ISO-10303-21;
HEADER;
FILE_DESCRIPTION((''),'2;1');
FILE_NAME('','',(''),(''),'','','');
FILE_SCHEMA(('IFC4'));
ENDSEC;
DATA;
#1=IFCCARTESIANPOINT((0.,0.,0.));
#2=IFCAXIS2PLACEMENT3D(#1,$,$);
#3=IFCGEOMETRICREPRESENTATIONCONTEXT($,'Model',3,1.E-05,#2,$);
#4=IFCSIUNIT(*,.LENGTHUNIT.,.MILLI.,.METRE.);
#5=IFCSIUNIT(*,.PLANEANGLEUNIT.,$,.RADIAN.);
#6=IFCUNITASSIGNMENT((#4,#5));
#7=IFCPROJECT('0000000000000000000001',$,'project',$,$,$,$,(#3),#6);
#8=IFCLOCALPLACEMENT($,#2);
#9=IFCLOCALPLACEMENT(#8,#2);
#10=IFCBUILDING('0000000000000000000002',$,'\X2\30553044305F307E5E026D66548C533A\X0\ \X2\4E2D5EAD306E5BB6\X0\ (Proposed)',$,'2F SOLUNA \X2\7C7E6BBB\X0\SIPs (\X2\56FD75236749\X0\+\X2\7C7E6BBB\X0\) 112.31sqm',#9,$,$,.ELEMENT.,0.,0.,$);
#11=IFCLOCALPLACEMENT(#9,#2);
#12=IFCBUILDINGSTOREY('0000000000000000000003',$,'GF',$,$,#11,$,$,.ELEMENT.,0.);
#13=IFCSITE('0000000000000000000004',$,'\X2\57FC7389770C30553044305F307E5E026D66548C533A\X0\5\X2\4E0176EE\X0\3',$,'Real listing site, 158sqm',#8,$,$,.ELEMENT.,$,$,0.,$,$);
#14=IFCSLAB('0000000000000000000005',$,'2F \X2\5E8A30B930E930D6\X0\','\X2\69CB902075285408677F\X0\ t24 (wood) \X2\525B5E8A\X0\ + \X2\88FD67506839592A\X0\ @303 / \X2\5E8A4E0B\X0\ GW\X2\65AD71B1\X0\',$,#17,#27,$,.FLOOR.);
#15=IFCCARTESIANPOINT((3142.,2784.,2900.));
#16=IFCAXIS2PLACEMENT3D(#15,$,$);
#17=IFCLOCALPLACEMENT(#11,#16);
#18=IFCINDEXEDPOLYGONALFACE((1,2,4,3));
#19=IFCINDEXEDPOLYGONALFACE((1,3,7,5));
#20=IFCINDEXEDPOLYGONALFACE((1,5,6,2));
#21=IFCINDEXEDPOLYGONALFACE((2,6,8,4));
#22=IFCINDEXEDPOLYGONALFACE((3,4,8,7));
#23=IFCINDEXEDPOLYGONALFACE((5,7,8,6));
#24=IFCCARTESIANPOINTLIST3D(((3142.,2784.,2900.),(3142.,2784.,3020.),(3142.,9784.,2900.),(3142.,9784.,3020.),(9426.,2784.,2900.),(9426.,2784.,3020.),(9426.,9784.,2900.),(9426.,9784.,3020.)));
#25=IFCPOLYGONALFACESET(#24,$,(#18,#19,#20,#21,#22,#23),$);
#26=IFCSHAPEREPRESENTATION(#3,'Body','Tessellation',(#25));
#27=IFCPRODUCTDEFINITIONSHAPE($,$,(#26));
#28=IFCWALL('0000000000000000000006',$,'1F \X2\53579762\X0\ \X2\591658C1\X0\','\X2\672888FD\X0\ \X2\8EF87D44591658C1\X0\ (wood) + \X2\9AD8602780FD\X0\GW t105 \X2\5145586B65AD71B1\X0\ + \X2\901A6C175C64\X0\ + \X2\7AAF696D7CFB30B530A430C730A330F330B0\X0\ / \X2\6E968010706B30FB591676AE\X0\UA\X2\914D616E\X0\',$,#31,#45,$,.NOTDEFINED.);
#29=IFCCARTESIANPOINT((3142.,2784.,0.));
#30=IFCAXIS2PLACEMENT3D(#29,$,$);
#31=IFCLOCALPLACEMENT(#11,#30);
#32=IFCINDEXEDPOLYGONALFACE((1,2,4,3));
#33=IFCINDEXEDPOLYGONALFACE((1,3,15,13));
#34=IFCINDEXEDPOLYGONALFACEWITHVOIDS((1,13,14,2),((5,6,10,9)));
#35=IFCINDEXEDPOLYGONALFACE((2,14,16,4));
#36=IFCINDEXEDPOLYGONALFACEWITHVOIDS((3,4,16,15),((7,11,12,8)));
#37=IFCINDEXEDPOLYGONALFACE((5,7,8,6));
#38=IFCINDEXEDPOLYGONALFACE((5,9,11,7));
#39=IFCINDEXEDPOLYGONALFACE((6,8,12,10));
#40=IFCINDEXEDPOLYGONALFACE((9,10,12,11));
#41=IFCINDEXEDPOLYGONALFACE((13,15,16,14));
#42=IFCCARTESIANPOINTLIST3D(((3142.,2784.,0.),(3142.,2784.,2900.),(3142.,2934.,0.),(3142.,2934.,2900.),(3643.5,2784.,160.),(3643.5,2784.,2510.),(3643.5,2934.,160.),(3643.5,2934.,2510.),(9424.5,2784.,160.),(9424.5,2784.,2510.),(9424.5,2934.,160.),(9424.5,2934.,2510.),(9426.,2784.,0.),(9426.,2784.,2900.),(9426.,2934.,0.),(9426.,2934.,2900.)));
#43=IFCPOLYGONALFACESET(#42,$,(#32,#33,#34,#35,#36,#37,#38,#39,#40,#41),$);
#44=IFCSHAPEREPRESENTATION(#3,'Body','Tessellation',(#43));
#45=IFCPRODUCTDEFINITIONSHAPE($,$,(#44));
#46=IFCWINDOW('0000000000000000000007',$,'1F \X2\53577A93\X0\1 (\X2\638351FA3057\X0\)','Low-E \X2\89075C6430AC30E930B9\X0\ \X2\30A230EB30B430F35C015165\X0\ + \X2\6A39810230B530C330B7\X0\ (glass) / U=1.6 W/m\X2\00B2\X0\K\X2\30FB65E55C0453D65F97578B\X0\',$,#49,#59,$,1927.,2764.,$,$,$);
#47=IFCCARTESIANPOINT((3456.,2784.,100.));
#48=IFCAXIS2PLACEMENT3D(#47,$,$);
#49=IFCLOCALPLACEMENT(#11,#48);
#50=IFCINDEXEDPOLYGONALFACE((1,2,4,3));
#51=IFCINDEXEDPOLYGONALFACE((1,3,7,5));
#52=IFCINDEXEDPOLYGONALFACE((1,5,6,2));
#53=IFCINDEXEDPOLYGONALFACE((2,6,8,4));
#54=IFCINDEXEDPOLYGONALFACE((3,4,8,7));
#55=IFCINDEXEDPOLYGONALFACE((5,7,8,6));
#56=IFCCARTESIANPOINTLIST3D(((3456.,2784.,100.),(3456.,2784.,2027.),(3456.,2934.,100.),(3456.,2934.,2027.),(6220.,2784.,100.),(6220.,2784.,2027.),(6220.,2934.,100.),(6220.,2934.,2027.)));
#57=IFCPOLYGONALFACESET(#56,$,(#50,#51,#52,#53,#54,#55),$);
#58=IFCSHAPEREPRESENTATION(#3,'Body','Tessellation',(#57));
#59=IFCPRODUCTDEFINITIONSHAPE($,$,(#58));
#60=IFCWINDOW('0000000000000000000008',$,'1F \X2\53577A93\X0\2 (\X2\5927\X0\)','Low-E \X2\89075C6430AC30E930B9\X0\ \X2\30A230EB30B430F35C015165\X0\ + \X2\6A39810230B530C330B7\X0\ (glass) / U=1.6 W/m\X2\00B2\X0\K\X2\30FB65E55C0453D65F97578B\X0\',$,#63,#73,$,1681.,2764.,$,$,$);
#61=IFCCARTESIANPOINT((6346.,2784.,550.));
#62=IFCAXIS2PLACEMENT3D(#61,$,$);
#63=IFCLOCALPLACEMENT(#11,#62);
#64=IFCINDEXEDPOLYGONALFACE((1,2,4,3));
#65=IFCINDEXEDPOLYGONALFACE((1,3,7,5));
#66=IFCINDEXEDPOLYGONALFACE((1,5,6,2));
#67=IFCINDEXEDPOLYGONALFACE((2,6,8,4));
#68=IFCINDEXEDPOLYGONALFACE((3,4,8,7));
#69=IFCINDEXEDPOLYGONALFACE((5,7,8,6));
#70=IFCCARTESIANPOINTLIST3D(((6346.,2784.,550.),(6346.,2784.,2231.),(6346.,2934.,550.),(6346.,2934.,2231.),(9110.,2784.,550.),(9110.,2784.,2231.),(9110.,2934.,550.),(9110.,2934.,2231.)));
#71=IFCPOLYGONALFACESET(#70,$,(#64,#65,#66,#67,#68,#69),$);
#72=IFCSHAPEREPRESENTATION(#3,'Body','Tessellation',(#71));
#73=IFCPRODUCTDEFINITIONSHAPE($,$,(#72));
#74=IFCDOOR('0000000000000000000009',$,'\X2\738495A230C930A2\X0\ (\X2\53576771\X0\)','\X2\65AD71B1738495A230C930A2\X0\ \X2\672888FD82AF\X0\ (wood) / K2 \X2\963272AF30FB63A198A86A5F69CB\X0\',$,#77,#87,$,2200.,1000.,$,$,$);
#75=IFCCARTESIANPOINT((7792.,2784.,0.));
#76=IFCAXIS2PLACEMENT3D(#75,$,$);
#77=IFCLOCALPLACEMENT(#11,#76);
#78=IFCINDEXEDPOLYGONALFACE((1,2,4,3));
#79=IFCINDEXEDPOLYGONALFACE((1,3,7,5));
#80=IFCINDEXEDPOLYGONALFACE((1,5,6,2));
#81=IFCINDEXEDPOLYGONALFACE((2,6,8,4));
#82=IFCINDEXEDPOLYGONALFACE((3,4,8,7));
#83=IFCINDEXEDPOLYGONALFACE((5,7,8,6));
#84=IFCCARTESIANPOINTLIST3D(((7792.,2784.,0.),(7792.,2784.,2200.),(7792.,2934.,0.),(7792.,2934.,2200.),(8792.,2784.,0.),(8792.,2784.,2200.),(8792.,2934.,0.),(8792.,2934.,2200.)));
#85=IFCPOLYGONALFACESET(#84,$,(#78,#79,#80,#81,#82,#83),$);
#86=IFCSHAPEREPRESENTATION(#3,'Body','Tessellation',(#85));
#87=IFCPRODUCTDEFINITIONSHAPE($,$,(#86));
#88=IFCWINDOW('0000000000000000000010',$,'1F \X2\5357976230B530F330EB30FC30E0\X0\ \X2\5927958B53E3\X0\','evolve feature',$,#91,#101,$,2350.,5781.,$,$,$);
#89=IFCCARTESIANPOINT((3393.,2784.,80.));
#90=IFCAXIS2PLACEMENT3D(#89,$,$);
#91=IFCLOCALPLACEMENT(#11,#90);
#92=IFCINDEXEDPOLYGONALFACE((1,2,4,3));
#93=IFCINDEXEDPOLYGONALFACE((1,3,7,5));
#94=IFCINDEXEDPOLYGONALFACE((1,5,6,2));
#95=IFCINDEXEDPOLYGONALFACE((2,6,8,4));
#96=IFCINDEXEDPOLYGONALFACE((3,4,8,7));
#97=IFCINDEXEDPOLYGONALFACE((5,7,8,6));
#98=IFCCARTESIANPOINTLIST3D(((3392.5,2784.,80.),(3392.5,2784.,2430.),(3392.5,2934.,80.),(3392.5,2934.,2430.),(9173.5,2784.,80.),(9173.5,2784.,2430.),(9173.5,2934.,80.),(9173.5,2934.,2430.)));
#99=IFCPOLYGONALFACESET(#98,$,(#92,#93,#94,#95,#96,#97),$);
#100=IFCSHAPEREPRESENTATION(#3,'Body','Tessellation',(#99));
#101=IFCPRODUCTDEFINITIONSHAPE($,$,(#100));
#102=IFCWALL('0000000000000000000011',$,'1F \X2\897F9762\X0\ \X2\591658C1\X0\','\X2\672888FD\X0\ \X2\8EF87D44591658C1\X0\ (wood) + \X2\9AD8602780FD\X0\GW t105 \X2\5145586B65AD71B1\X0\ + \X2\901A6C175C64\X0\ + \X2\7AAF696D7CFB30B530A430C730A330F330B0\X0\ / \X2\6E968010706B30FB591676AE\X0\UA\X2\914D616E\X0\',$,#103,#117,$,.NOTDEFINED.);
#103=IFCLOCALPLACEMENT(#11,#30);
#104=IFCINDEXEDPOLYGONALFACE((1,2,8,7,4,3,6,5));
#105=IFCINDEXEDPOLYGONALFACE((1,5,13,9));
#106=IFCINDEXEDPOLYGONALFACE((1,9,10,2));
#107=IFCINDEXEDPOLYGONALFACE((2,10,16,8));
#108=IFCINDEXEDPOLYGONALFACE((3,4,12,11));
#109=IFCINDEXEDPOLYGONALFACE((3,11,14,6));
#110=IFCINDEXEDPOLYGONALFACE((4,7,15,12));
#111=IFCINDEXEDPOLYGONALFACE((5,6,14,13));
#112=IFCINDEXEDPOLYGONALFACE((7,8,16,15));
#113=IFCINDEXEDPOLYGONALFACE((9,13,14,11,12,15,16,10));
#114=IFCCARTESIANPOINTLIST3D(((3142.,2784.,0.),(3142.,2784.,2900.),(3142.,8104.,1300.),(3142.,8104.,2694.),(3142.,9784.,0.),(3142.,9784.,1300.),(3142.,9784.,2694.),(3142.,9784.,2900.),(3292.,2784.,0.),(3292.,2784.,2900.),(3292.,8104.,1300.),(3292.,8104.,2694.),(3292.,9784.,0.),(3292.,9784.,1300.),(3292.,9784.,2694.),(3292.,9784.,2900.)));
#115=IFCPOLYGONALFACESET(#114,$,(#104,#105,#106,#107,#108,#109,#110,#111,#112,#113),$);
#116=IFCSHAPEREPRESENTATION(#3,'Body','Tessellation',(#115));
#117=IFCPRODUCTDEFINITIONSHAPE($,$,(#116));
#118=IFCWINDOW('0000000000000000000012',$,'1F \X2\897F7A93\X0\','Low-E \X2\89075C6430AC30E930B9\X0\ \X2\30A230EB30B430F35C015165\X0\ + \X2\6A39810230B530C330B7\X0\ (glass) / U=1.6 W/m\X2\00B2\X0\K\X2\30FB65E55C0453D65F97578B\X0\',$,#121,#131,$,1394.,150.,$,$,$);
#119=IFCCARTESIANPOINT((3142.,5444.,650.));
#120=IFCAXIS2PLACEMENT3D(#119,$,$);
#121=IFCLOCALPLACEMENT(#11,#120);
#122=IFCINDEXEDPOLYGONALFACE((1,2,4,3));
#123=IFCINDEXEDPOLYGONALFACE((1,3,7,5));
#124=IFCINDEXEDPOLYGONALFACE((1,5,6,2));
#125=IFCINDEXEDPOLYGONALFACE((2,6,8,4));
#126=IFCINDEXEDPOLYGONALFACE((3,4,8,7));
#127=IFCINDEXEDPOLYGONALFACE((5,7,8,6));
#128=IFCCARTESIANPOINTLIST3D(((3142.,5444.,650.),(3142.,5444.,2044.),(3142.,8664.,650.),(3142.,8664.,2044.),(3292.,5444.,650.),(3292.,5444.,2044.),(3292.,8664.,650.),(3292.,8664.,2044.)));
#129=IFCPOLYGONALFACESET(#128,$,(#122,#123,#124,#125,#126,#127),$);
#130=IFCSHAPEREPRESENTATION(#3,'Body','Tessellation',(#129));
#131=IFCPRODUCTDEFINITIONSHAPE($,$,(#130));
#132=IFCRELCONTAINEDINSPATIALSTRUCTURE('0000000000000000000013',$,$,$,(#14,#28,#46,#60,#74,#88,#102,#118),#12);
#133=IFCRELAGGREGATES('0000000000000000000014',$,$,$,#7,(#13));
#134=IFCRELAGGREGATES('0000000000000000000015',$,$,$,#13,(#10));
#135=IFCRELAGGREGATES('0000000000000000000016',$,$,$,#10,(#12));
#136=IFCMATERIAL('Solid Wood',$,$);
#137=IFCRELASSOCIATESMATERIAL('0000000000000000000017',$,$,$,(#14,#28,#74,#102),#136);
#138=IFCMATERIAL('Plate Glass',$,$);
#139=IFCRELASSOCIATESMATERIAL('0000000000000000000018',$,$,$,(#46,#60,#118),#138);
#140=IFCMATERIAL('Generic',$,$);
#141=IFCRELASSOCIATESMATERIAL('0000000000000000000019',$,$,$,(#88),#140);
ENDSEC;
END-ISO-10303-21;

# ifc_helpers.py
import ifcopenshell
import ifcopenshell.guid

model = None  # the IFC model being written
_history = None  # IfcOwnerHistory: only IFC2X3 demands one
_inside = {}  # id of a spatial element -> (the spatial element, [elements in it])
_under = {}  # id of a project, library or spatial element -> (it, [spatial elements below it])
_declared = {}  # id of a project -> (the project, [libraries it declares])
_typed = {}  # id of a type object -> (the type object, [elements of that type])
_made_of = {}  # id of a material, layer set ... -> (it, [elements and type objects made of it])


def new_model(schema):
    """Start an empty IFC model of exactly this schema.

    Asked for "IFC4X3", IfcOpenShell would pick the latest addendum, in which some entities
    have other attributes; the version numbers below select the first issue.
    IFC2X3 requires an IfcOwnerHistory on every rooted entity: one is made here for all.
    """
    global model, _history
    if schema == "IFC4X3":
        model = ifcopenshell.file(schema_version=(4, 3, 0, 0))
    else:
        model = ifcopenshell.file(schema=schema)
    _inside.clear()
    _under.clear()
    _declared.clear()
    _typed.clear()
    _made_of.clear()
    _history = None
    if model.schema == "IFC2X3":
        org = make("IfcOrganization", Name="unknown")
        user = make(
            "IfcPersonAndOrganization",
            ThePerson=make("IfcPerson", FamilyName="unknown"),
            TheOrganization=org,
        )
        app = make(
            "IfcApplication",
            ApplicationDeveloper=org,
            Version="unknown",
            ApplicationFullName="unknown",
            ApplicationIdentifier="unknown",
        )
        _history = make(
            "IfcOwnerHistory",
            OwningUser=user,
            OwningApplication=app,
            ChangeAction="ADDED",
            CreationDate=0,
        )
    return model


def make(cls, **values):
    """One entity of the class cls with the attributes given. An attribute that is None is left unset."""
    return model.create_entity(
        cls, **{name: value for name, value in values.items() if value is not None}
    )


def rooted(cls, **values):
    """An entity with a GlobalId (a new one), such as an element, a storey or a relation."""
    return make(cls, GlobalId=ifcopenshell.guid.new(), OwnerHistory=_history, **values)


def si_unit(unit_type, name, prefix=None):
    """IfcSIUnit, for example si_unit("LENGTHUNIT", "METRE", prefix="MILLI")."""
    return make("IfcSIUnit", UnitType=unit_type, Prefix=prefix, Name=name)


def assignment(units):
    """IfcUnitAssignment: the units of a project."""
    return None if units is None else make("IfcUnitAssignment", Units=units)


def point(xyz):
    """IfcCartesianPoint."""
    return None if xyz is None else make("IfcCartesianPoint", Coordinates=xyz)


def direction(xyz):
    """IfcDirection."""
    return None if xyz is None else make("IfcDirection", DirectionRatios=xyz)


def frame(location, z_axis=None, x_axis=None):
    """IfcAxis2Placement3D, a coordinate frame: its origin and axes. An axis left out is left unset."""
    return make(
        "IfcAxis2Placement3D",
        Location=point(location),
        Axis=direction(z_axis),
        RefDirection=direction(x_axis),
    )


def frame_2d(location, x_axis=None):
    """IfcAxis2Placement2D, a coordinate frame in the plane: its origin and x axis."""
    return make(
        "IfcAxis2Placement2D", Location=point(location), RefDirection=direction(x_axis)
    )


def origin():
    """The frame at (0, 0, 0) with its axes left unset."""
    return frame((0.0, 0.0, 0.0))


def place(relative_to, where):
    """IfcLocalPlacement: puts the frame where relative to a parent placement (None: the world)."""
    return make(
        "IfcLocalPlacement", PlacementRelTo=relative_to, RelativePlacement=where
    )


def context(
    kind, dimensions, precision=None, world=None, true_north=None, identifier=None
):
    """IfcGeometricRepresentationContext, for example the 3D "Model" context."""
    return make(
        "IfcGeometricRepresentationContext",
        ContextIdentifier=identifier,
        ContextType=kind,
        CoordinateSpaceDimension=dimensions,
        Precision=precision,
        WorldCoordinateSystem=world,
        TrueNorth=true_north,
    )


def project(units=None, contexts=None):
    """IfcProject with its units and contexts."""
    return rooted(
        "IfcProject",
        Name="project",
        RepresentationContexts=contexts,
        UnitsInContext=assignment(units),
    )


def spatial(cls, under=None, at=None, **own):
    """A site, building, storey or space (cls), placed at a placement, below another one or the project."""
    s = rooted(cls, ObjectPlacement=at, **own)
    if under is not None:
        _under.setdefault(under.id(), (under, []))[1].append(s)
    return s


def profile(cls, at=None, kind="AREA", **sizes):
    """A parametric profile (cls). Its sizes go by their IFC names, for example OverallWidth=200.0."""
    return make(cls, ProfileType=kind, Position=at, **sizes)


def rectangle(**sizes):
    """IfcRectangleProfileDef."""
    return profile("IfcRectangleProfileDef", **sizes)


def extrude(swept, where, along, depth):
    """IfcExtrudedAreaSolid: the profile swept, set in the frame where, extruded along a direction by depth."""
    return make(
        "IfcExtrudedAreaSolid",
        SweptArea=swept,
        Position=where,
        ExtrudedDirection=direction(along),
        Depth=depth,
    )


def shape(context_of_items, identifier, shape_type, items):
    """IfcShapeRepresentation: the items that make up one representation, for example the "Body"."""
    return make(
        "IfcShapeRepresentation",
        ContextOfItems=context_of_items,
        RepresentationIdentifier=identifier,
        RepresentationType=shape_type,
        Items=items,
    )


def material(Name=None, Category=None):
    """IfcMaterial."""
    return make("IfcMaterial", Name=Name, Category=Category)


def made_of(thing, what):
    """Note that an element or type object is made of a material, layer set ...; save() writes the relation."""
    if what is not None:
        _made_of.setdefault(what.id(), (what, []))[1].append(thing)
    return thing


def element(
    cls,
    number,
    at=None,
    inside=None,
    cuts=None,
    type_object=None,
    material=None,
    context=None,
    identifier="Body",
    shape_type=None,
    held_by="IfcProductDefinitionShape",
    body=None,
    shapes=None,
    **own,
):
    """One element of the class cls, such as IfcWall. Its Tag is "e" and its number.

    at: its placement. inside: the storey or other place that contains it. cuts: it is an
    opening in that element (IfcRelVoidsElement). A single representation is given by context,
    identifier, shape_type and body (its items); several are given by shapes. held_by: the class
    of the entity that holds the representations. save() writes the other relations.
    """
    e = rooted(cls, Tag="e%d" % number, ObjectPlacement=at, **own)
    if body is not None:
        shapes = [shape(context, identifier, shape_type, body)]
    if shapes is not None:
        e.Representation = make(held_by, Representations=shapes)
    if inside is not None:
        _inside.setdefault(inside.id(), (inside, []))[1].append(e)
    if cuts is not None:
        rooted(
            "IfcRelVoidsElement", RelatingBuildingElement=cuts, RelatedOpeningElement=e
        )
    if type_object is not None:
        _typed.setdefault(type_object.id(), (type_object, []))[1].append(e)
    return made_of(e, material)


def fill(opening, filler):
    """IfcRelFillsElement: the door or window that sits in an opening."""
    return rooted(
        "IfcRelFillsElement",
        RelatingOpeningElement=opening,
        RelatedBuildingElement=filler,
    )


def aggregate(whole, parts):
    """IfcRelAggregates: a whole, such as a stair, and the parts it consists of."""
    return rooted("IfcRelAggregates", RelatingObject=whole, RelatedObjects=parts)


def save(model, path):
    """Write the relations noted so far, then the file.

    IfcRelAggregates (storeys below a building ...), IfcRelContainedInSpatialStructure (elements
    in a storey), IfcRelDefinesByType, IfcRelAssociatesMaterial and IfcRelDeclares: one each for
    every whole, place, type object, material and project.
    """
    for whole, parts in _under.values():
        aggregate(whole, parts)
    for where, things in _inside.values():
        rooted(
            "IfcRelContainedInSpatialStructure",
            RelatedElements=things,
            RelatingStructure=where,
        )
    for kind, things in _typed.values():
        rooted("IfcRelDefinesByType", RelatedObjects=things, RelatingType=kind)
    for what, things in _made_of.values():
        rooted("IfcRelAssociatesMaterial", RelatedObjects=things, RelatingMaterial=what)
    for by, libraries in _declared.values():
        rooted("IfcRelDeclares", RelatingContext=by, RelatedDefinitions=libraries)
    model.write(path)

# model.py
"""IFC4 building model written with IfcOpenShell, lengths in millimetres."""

from ifc_helpers import new_model, si_unit, frame, frame_2d, origin, place, context, project, spatial, rectangle, extrude, material, element, fill, save


model = new_model("IFC4")

# Units and contexts
model_context = context("Model", 3, precision=1e-05, world=origin())
ifc_project = project(units=[si_unit("LENGTHUNIT", "METRE", prefix="MILLI"), si_unit("PLANEANGLEUNIT", "RADIAN")], contexts=[model_context])

# Site, building, storey
site_placement = place(None, origin())
site = spatial("IfcSite", under=ifc_project, at=site_placement, Name="埼玉県さいたま市浦和区5丁目3", ObjectType="Real listing site, 158sqm", CompositionType="ELEMENT", RefElevation=0.0)
building_placement = place(site_placement, origin())
building = spatial("IfcBuilding", under=site, at=building_placement, Name="さいたま市浦和区 中庭の家 (Proposed)", ObjectType="2F SOLUNA 籾殻SIPs (国産杉+籾殻) 112.31sqm", CompositionType="ELEMENT", ElevationOfRefHeight=0.0, ElevationOfTerrain=0.0)
storey_placement = place(building_placement, origin())
storey = spatial("IfcBuildingStorey", under=building, at=storey_placement, Name="GF", CompositionType="ELEMENT", Elevation=0.0)

# Slab
ifc_material_1 = material(Name="Solid Wood")
slab_1_placement = place(storey_placement, frame((3142.0, 2784.0, 2900.0)))
element("IfcSlab", 1, at=slab_1_placement, inside=storey, material=ifc_material_1, Name="2F 床スラブ", Description="構造用合板 t24 (wood) 剛床 + 製材根太 @303 / 床下 GW断熱", PredefinedType="FLOOR", context=model_context, shape_type="SweptSolid", body=[
    extrude(rectangle(XDim=6284.0, YDim=7000.0, at=frame_2d((3142.0, 3500.0))), frame((3142.0, 2784.0, 2900.0)), (0.0, 0.0, 1.0), 120.0),
])
ifc_material_2 = material(Name="Generic")

# Wall, openings, windows, door
wall_1_placement = place(storey_placement, frame((3142.0, 2784.0, 0.0)))
wall_1 = element("IfcWall", 2, at=wall_1_placement, inside=storey, material=ifc_material_1, Name="1F 南面 外壁", Description="木製 軸組外壁 (wood) + 高性能GW t105 充填断熱 + 通気層 + 窯業系サイディング / 準耐火・外皮UA配慮", PredefinedType="NOTDEFINED", context=model_context, shape_type="SweptSolid", body=[
    extrude(rectangle(XDim=6284.0, YDim=150.0, at=frame_2d((3142.0, 75.0))), frame((3142.0, 2784.0, 0.0)), (0.0, 0.0, 1.0), 2900.0),
])
opening_1_placement = place(storey_placement, frame((3456.0, 2784.0, 100.0)))
opening_1 = element("IfcOpeningElement", 3, at=opening_1_placement, cuts=wall_1, PredefinedType="NOTDEFINED", context=model_context, shape_type="SweptSolid", body=[
    extrude(rectangle(XDim=2764.0, YDim=150.0, at=frame_2d((1382.0, 75.0))), frame((3456.0, 2784.0, 100.0)), (0.0, 0.0, 1.0), 1927.0),
])
opening_2_placement = place(storey_placement, frame((6346.0, 2784.0, 550.0)))
opening_2 = element("IfcOpeningElement", 4, at=opening_2_placement, cuts=wall_1, PredefinedType="NOTDEFINED", context=model_context, shape_type="SweptSolid", body=[
    extrude(rectangle(XDim=2764.0, YDim=150.0, at=frame_2d((1382.0, 75.0))), frame((6346.0, 2784.0, 550.0)), (0.0, 0.0, 1.0), 1681.0),
])
opening_3_placement = place(storey_placement, frame((7792.0, 2784.0, 0.0)))
opening_3 = element("IfcOpeningElement", 5, at=opening_3_placement, cuts=wall_1, PredefinedType="NOTDEFINED", context=model_context, shape_type="SweptSolid", body=[
    extrude(rectangle(XDim=1000.0, YDim=150.0, at=frame_2d((500.0, 75.0))), frame((7792.0, 2784.0, 0.0)), (0.0, 0.0, 1.0), 2200.0),
])
opening_4_placement = place(storey_placement, frame((3393.0, 2784.0, 80.0)))
opening_4 = element("IfcOpeningElement", 6, at=opening_4_placement, cuts=wall_1, PredefinedType="NOTDEFINED", context=model_context, shape_type="SweptSolid", body=[
    extrude(rectangle(XDim=5781.0, YDim=150.0, at=frame_2d((2890.0, 75.0))), frame((3393.0, 2784.0, 80.0)), (0.0, 0.0, 1.0), 2350.0),
])
ifc_material_3 = material(Name="Plate Glass")
window_1_placement = place(storey_placement, frame((3456.0, 2784.0, 100.0)))
window_1 = element("IfcWindow", 7, at=window_1_placement, inside=storey, material=ifc_material_3, Name="1F 南窓1 (掃出し)", Description="Low-E 複層ガラス アルゴン封入 + 樹脂サッシ (glass) / U=1.6 W/m²K・日射取得型", OverallHeight=1927.0, OverallWidth=2764.0, context=model_context, shape_type="SweptSolid", body=[
    extrude(rectangle(XDim=2764.0, YDim=150.0, at=frame_2d((1382.0, 75.0))), frame((3456.0, 2784.0, 100.0)), (0.0, 0.0, 1.0), 1927.0),
])
fill(opening_1, window_1)
window_2_placement = place(storey_placement, frame((6346.0, 2784.0, 550.0)))
window_2 = element("IfcWindow", 8, at=window_2_placement, inside=storey, material=ifc_material_3, Name="1F 南窓2 (大)", Description="Low-E 複層ガラス アルゴン封入 + 樹脂サッシ (glass) / U=1.6 W/m²K・日射取得型", OverallHeight=1681.0, OverallWidth=2764.0, context=model_context, shape_type="SweptSolid", body=[
    extrude(rectangle(XDim=2764.0, YDim=150.0, at=frame_2d((1382.0, 75.0))), frame((6346.0, 2784.0, 550.0)), (0.0, 0.0, 1.0), 1681.0),
])
fill(opening_2, window_2)
door_placement = place(storey_placement, frame((7792.0, 2784.0, 0.0)))
door = element("IfcDoor", 9, at=door_placement, inside=storey, material=ifc_material_1, Name="玄関ドア (南東)", Description="断熱玄関ドア 木製芯 (wood) / K2 防犯・採風機構", OverallHeight=2200.0, OverallWidth=1000.0, context=model_context, shape_type="SweptSolid", body=[
    extrude(rectangle(XDim=1000.0, YDim=150.0, at=frame_2d((500.0, 75.0))), frame((7792.0, 2784.0, 0.0)), (0.0, 0.0, 1.0), 2200.0),
])
fill(opening_3, door)
window_3_placement = place(storey_placement, frame((3393.0, 2784.0, 80.0)))
window_3 = element("IfcWindow", 10, at=window_3_placement, inside=storey, material=ifc_material_2, Name="1F 南面サンルーム 大開口", Description="evolve feature", OverallHeight=2350.0, OverallWidth=5781.0, context=model_context, shape_type="SweptSolid", body=[
    extrude(rectangle(XDim=5781.0, YDim=150.0, at=frame_2d((2890.0, 75.0))), frame((3393.0, 2784.0, 80.0)), (0.0, 0.0, 1.0), 2350.0),
])
fill(opening_4, window_3)

# Wall, opening, window
wall_2_placement = place(storey_placement, frame((3142.0, 2784.0, 0.0)))
wall_2 = element("IfcWall", 11, at=wall_2_placement, inside=storey, material=ifc_material_1, Name="1F 西面 外壁", Description="木製 軸組外壁 (wood) + 高性能GW t105 充填断熱 + 通気層 + 窯業系サイディング / 準耐火・外皮UA配慮", PredefinedType="NOTDEFINED", context=model_context, shape_type="SweptSolid", body=[
    extrude(rectangle(XDim=150.0, YDim=7000.0, at=frame_2d((75.0, 3500.0))), frame((3142.0, 2784.0, 0.0)), (0.0, 0.0, 1.0), 2900.0),
])
opening_5_placement = place(storey_placement, frame((3142.0, 5444.0, 650.0)))
opening_5 = element("IfcOpeningElement", 12, at=opening_5_placement, cuts=wall_2, PredefinedType="NOTDEFINED", context=model_context, shape_type="SweptSolid", body=[
    extrude(rectangle(XDim=150.0, YDim=3220.0, at=frame_2d((75.0, 1610.0))), frame((3142.0, 5444.0, 650.0)), (0.0, 0.0, 1.0), 1394.0),
])
window_4_placement = place(storey_placement, frame((3142.0, 5444.0, 650.0)))
window_4 = element("IfcWindow", 13, at=window_4_placement, inside=storey, material=ifc_material_3, Name="1F 西窓", Description="Low-E 複層ガラス アルゴン封入 + 樹脂サッシ (glass) / U=1.6 W/m²K・日射取得型", OverallHeight=1394.0, OverallWidth=150.0, context=model_context, shape_type="SweptSolid", body=[
    extrude(rectangle(XDim=150.0, YDim=3220.0, at=frame_2d((75.0, 1610.0))), frame((3142.0, 5444.0, 650.0)), (0.0, 0.0, 1.0), 1394.0),
])
fill(opening_5, window_4)

save(model, "model.ifc")
